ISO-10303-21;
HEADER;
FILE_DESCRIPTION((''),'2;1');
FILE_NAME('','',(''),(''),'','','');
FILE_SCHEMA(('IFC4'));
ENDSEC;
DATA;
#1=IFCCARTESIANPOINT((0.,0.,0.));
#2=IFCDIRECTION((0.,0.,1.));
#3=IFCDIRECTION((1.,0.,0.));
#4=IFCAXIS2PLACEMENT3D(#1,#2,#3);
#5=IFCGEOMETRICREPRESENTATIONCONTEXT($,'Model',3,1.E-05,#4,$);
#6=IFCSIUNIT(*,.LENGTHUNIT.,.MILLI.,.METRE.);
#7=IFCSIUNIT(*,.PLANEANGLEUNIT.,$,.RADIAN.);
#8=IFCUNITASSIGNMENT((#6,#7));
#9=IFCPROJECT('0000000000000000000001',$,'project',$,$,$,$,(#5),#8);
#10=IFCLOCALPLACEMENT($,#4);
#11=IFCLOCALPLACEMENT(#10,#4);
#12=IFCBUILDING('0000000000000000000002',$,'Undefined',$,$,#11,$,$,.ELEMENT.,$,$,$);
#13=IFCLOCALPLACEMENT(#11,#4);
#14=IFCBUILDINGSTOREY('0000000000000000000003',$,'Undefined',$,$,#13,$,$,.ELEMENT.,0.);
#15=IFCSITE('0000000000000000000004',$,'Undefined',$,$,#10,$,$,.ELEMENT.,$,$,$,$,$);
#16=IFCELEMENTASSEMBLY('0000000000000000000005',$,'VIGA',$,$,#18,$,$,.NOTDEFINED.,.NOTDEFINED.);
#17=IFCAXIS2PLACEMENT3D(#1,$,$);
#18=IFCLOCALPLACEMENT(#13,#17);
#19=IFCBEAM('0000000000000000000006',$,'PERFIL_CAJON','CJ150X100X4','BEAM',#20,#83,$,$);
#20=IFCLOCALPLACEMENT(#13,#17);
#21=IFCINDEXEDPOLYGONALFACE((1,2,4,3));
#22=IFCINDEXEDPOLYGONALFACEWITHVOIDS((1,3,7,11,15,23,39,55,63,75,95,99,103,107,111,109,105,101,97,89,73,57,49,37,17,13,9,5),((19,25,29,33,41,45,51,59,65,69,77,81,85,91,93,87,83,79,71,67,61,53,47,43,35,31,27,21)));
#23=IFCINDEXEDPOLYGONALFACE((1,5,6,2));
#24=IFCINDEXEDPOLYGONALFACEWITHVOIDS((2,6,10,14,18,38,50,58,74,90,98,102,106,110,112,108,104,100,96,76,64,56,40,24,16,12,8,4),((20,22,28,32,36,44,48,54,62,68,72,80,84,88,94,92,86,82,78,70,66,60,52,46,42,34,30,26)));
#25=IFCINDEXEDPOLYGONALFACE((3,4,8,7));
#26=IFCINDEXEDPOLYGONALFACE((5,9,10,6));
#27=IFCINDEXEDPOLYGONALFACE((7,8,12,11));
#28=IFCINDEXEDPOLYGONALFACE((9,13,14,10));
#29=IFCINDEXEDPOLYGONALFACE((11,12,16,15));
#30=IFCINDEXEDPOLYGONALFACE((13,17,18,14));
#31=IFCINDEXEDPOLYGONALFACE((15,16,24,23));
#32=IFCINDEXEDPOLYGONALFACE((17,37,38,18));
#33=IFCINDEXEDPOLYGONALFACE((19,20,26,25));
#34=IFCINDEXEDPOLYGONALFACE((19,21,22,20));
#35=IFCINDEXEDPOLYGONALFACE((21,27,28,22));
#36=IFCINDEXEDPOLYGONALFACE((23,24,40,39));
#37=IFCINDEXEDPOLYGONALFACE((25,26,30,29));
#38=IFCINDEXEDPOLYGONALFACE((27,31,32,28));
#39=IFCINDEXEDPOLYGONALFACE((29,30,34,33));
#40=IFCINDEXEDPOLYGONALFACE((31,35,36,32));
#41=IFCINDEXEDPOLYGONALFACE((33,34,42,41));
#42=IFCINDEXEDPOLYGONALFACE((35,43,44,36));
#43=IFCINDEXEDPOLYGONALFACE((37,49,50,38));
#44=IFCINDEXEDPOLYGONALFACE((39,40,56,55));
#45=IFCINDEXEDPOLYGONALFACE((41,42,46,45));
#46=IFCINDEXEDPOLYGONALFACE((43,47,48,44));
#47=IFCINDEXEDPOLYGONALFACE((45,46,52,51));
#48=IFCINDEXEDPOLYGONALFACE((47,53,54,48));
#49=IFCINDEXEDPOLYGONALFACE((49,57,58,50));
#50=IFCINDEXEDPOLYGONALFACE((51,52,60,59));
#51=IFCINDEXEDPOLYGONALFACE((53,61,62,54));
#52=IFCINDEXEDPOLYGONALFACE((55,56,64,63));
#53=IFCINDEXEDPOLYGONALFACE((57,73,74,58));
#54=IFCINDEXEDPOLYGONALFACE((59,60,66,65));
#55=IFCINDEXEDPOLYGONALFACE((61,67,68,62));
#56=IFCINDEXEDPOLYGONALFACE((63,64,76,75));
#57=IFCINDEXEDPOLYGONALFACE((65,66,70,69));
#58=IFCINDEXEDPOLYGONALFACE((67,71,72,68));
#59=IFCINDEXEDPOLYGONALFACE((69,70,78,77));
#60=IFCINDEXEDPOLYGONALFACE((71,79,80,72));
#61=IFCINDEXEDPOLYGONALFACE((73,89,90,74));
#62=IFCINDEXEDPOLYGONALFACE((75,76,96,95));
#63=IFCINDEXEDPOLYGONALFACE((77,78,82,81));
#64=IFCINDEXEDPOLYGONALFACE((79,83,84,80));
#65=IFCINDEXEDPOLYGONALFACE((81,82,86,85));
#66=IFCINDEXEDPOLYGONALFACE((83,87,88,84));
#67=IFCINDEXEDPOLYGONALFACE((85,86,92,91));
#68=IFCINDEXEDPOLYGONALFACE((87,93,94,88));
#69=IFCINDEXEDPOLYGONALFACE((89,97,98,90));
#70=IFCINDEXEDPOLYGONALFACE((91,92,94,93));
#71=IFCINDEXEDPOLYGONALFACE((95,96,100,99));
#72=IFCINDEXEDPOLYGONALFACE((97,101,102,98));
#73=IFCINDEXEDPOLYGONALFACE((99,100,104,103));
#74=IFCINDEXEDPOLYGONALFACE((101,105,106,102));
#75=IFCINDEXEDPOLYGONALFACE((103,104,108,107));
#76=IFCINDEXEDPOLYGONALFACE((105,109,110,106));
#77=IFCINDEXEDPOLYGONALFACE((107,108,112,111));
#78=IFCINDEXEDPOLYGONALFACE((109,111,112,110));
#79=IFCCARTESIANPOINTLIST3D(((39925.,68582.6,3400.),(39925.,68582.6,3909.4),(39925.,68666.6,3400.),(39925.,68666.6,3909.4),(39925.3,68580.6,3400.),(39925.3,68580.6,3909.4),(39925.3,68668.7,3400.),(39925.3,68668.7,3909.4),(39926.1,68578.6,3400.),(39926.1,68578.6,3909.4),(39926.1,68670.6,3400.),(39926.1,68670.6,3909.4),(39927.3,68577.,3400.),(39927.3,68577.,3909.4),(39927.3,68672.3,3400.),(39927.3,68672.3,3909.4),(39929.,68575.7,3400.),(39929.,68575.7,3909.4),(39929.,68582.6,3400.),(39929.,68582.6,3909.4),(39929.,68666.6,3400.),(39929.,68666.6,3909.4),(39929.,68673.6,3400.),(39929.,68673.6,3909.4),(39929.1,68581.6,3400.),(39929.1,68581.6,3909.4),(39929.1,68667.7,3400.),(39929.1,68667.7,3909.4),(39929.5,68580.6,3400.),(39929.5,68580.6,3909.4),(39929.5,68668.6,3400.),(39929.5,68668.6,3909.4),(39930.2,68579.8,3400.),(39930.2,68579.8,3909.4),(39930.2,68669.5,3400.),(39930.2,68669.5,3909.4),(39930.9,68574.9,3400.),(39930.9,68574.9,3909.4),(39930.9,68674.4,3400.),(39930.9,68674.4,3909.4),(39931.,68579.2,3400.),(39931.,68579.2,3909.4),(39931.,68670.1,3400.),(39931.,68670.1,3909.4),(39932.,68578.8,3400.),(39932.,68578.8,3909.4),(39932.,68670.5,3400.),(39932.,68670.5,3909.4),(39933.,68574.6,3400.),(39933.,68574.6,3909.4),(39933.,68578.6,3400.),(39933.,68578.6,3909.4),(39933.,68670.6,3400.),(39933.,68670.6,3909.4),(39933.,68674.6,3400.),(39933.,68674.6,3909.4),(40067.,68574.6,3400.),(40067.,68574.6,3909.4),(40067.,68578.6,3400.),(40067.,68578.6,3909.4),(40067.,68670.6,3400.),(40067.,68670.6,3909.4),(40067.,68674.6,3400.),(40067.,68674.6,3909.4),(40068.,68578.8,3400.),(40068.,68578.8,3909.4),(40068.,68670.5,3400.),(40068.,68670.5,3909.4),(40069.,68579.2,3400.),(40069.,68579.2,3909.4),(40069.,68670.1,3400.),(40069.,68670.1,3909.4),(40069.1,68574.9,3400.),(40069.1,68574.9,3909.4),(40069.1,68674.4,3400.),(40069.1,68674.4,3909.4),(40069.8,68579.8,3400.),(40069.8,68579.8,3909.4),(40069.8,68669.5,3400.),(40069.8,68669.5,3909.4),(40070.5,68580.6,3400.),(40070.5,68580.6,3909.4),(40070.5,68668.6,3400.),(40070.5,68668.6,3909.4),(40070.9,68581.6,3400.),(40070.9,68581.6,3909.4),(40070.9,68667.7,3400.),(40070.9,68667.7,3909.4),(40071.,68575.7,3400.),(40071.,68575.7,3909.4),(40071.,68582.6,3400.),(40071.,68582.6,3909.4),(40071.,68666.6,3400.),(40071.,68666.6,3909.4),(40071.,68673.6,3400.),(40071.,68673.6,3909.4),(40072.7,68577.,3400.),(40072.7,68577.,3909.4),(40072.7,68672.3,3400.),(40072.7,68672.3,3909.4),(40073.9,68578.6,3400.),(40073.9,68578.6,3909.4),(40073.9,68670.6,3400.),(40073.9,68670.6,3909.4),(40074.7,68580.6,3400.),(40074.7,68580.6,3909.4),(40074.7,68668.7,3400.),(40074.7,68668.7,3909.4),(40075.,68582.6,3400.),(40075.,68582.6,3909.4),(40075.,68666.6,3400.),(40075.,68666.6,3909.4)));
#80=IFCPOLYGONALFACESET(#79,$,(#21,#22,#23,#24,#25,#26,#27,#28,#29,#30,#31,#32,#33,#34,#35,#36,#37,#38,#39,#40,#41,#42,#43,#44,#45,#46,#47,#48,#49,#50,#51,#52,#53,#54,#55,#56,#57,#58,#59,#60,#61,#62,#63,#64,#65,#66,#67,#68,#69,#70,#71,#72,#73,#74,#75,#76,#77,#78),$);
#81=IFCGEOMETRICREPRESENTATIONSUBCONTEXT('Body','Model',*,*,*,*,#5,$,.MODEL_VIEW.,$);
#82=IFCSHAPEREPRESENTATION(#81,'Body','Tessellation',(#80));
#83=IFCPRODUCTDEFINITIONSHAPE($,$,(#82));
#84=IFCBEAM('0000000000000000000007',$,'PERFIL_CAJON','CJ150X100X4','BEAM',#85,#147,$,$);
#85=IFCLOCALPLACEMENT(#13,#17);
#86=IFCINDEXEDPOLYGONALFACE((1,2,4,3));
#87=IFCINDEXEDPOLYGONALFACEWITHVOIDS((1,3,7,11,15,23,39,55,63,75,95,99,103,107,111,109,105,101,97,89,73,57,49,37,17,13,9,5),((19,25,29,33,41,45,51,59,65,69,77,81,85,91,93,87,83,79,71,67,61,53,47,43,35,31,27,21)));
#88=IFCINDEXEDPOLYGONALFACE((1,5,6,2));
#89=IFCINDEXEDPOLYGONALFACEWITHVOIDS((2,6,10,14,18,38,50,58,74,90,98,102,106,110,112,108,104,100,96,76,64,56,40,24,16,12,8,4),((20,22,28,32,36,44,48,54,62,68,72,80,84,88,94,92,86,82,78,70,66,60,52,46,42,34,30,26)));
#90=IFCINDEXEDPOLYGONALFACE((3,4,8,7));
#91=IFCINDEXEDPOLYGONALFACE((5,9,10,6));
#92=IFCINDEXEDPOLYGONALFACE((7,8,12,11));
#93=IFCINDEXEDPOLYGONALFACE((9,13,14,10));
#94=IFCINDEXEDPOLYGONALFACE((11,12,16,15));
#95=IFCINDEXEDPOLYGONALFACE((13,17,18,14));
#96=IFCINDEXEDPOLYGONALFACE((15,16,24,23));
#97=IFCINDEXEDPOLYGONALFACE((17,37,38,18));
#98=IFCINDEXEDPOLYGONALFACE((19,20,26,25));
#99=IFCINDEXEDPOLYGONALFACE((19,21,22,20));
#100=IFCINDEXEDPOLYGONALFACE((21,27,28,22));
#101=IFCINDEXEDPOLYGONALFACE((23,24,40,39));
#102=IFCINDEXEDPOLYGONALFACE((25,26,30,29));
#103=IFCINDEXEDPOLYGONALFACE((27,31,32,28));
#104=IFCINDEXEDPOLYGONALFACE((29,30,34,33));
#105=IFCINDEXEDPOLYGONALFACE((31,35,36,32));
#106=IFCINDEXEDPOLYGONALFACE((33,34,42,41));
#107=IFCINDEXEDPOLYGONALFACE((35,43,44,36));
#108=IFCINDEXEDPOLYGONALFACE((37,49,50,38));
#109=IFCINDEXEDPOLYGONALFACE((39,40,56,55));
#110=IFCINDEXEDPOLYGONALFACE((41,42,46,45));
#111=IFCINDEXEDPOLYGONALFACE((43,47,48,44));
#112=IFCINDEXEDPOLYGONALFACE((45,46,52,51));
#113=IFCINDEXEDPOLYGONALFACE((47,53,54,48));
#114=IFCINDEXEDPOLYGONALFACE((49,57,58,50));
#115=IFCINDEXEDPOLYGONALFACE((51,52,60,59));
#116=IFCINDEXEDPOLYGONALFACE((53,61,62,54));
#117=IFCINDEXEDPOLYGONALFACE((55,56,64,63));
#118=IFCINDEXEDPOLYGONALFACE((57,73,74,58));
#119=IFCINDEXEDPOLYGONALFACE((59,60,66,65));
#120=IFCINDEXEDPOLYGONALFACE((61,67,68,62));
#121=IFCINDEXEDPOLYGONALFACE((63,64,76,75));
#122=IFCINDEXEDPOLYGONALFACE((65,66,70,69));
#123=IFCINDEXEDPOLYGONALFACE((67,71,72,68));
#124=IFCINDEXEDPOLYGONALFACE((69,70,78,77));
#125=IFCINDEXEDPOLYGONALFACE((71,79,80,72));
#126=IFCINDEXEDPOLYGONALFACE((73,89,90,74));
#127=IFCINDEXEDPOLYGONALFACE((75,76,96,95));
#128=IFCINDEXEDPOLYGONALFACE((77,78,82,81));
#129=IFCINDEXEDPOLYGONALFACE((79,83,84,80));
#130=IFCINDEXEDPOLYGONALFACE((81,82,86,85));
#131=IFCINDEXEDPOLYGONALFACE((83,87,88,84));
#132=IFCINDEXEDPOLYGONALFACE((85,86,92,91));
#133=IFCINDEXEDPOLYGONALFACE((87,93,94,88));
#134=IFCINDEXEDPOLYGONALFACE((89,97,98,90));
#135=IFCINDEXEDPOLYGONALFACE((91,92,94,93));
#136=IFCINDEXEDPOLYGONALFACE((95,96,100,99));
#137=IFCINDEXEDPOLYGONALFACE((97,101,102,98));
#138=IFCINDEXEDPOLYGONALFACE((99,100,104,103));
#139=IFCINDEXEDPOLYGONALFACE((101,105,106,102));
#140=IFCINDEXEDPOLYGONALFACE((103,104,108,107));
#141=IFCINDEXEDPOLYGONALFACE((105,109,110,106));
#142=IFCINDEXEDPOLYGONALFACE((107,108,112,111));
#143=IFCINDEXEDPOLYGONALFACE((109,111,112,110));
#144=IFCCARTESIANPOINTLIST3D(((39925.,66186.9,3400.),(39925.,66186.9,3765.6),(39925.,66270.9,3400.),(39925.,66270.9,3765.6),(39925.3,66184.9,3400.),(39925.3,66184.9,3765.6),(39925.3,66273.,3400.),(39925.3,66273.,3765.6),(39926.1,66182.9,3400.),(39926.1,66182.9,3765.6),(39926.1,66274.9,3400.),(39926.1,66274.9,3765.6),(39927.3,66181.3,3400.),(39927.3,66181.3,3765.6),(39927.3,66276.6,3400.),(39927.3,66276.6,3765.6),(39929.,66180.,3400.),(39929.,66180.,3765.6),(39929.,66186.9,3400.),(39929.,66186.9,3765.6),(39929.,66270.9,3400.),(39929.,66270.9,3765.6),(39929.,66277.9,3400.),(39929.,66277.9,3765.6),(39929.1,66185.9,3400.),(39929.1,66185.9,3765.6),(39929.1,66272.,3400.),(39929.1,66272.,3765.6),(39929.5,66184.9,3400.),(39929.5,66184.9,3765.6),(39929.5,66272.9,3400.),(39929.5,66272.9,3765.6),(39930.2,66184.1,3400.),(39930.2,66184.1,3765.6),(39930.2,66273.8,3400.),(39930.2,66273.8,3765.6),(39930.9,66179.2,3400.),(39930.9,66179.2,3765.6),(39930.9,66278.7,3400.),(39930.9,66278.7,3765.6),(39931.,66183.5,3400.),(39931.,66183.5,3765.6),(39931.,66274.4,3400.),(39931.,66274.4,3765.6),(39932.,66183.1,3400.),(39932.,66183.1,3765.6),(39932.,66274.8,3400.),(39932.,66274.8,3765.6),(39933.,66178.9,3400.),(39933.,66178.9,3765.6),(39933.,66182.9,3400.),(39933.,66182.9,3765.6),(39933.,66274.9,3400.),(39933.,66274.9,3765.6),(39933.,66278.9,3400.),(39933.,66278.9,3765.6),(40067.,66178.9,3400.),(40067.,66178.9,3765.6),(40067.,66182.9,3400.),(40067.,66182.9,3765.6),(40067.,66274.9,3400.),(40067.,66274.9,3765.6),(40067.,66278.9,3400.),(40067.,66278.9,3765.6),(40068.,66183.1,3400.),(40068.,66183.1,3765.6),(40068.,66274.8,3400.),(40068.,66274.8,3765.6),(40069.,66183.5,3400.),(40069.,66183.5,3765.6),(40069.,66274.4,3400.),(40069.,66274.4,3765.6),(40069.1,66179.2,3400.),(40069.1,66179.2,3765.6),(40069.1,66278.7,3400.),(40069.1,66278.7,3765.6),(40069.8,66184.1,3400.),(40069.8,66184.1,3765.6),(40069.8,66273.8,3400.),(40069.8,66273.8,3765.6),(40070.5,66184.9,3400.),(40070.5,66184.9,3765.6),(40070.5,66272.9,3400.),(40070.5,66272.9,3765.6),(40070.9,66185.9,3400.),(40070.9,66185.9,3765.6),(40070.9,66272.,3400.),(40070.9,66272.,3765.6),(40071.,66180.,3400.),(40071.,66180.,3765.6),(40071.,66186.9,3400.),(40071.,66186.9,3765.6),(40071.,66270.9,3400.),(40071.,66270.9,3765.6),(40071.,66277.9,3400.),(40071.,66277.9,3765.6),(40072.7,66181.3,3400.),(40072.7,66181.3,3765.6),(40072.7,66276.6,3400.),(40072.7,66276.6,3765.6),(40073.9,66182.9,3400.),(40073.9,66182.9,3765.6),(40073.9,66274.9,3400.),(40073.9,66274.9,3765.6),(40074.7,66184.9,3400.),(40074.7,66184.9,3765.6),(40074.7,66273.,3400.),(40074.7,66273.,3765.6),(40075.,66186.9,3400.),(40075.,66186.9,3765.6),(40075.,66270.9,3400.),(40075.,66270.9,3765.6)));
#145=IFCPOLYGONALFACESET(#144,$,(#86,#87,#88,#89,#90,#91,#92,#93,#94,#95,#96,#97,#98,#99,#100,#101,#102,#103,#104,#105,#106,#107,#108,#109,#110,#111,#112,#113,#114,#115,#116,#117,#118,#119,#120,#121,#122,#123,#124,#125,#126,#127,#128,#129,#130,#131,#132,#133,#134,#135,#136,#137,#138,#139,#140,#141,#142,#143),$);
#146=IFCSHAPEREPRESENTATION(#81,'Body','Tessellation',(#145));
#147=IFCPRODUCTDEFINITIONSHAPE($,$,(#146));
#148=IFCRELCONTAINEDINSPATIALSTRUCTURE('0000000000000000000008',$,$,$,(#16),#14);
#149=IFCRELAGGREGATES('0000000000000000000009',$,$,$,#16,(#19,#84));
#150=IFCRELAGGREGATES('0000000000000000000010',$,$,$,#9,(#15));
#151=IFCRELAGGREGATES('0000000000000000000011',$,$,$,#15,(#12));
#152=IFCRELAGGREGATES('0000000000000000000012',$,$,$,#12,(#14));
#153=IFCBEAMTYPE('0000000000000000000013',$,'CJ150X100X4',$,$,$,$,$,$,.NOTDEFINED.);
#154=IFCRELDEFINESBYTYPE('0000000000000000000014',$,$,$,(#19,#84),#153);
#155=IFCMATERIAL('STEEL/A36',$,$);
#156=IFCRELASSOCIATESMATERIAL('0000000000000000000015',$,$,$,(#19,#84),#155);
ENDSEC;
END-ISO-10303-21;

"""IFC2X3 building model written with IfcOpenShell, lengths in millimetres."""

from ifc_helpers import new_model, si_unit, frame, origin_with_axes, origin_2d_with_axis, place, context, subcontext, project, spatial, hollow_rectangle, extrude, material, type_object, element, aggregate, save


model = new_model("IFC2X3")

# Units and contexts
model_context = context("Model", 3, precision=1e-05, world=origin_with_axes())
body_context = subcontext(model_context, "Body", "Model", "MODEL_VIEW")
ifc_project = project(units=[si_unit("LENGTHUNIT", "METRE", prefix="MILLI"), si_unit("PLANEANGLEUNIT", "RADIAN")], contexts=[model_context])

# Site, building, storey
site_placement = place(None, origin_with_axes())
site = spatial("IfcSite", under=ifc_project, at=site_placement, Name="Undefined", CompositionType="ELEMENT")
building_placement = place(site_placement, origin_with_axes())
building = spatial("IfcBuilding", under=site, at=building_placement, Name="Undefined", CompositionType="ELEMENT")
storey_placement = place(building_placement, origin_with_axes())
storey = spatial("IfcBuildingStorey", under=building, at=storey_placement, Name="Undefined", CompositionType="ELEMENT", Elevation=0.0)

# Shared definitions
ifc_material_1 = material(Name="STEEL/A36")
beam_type = type_object("IfcBeamType", Name="CJ150X100X4", PredefinedType="NOTDEFINED")

# Element assembly, beams
assembly_1_placement = place(storey_placement, origin_with_axes())
assembly_1 = element("IfcElementAssembly", 1, at=assembly_1_placement, inside=storey, Name="VIGA", AssemblyPlace="NOTDEFINED", PredefinedType="NOTDEFINED")
beam_1_placement = place(assembly_1_placement, frame((40000.0, 68624.6, 3909.4), z_axis=(-1.0, 0.0, 0.0), x_axis=(0.0, 0.0, -1.0)))
beam_1 = element("IfcBeam", 2, at=beam_1_placement, type_object=beam_type, material=ifc_material_1, Name="PERFIL_CAJON", Description="CJ150X100X4", ObjectType="BEAM", context=body_context, shape_type="SweptSolid", body=[
    extrude(hollow_rectangle(XDim=100.0, YDim=150.0, WallThickness=4.0, InnerFilletRadius=4.0, OuterFilletRadius=8.0, at=origin_2d_with_axis()), frame((509.4, 0.0, 0.0), z_axis=(-1.0, 0.0, 0.0), x_axis=(0.0, -1.0, 0.0)), (0.0, 0.0, 1.0), 509.4),
])
beam_2_placement = place(assembly_1_placement, frame((40000.0, 66228.9, 3765.6), z_axis=(-1.0, 0.0, 0.0), x_axis=(0.0, 0.0, -1.0)))
beam_2 = element("IfcBeam", 3, at=beam_2_placement, type_object=beam_type, material=ifc_material_1, Name="PERFIL_CAJON", Description="CJ150X100X4", ObjectType="BEAM", context=body_context, shape_type="SweptSolid", body=[
    extrude(hollow_rectangle(XDim=100.0, YDim=150.0, WallThickness=4.0, InnerFilletRadius=4.0, OuterFilletRadius=8.0, at=origin_2d_with_axis()), frame((365.6, 0.0, 0.0), z_axis=(-1.0, 0.0, 0.0), x_axis=(0.0, -1.0, 0.0)), (0.0, 0.0, 1.0), 365.6),
])
aggregate(assembly_1, [beam_1, beam_2])

save(model, "model.ifc")
